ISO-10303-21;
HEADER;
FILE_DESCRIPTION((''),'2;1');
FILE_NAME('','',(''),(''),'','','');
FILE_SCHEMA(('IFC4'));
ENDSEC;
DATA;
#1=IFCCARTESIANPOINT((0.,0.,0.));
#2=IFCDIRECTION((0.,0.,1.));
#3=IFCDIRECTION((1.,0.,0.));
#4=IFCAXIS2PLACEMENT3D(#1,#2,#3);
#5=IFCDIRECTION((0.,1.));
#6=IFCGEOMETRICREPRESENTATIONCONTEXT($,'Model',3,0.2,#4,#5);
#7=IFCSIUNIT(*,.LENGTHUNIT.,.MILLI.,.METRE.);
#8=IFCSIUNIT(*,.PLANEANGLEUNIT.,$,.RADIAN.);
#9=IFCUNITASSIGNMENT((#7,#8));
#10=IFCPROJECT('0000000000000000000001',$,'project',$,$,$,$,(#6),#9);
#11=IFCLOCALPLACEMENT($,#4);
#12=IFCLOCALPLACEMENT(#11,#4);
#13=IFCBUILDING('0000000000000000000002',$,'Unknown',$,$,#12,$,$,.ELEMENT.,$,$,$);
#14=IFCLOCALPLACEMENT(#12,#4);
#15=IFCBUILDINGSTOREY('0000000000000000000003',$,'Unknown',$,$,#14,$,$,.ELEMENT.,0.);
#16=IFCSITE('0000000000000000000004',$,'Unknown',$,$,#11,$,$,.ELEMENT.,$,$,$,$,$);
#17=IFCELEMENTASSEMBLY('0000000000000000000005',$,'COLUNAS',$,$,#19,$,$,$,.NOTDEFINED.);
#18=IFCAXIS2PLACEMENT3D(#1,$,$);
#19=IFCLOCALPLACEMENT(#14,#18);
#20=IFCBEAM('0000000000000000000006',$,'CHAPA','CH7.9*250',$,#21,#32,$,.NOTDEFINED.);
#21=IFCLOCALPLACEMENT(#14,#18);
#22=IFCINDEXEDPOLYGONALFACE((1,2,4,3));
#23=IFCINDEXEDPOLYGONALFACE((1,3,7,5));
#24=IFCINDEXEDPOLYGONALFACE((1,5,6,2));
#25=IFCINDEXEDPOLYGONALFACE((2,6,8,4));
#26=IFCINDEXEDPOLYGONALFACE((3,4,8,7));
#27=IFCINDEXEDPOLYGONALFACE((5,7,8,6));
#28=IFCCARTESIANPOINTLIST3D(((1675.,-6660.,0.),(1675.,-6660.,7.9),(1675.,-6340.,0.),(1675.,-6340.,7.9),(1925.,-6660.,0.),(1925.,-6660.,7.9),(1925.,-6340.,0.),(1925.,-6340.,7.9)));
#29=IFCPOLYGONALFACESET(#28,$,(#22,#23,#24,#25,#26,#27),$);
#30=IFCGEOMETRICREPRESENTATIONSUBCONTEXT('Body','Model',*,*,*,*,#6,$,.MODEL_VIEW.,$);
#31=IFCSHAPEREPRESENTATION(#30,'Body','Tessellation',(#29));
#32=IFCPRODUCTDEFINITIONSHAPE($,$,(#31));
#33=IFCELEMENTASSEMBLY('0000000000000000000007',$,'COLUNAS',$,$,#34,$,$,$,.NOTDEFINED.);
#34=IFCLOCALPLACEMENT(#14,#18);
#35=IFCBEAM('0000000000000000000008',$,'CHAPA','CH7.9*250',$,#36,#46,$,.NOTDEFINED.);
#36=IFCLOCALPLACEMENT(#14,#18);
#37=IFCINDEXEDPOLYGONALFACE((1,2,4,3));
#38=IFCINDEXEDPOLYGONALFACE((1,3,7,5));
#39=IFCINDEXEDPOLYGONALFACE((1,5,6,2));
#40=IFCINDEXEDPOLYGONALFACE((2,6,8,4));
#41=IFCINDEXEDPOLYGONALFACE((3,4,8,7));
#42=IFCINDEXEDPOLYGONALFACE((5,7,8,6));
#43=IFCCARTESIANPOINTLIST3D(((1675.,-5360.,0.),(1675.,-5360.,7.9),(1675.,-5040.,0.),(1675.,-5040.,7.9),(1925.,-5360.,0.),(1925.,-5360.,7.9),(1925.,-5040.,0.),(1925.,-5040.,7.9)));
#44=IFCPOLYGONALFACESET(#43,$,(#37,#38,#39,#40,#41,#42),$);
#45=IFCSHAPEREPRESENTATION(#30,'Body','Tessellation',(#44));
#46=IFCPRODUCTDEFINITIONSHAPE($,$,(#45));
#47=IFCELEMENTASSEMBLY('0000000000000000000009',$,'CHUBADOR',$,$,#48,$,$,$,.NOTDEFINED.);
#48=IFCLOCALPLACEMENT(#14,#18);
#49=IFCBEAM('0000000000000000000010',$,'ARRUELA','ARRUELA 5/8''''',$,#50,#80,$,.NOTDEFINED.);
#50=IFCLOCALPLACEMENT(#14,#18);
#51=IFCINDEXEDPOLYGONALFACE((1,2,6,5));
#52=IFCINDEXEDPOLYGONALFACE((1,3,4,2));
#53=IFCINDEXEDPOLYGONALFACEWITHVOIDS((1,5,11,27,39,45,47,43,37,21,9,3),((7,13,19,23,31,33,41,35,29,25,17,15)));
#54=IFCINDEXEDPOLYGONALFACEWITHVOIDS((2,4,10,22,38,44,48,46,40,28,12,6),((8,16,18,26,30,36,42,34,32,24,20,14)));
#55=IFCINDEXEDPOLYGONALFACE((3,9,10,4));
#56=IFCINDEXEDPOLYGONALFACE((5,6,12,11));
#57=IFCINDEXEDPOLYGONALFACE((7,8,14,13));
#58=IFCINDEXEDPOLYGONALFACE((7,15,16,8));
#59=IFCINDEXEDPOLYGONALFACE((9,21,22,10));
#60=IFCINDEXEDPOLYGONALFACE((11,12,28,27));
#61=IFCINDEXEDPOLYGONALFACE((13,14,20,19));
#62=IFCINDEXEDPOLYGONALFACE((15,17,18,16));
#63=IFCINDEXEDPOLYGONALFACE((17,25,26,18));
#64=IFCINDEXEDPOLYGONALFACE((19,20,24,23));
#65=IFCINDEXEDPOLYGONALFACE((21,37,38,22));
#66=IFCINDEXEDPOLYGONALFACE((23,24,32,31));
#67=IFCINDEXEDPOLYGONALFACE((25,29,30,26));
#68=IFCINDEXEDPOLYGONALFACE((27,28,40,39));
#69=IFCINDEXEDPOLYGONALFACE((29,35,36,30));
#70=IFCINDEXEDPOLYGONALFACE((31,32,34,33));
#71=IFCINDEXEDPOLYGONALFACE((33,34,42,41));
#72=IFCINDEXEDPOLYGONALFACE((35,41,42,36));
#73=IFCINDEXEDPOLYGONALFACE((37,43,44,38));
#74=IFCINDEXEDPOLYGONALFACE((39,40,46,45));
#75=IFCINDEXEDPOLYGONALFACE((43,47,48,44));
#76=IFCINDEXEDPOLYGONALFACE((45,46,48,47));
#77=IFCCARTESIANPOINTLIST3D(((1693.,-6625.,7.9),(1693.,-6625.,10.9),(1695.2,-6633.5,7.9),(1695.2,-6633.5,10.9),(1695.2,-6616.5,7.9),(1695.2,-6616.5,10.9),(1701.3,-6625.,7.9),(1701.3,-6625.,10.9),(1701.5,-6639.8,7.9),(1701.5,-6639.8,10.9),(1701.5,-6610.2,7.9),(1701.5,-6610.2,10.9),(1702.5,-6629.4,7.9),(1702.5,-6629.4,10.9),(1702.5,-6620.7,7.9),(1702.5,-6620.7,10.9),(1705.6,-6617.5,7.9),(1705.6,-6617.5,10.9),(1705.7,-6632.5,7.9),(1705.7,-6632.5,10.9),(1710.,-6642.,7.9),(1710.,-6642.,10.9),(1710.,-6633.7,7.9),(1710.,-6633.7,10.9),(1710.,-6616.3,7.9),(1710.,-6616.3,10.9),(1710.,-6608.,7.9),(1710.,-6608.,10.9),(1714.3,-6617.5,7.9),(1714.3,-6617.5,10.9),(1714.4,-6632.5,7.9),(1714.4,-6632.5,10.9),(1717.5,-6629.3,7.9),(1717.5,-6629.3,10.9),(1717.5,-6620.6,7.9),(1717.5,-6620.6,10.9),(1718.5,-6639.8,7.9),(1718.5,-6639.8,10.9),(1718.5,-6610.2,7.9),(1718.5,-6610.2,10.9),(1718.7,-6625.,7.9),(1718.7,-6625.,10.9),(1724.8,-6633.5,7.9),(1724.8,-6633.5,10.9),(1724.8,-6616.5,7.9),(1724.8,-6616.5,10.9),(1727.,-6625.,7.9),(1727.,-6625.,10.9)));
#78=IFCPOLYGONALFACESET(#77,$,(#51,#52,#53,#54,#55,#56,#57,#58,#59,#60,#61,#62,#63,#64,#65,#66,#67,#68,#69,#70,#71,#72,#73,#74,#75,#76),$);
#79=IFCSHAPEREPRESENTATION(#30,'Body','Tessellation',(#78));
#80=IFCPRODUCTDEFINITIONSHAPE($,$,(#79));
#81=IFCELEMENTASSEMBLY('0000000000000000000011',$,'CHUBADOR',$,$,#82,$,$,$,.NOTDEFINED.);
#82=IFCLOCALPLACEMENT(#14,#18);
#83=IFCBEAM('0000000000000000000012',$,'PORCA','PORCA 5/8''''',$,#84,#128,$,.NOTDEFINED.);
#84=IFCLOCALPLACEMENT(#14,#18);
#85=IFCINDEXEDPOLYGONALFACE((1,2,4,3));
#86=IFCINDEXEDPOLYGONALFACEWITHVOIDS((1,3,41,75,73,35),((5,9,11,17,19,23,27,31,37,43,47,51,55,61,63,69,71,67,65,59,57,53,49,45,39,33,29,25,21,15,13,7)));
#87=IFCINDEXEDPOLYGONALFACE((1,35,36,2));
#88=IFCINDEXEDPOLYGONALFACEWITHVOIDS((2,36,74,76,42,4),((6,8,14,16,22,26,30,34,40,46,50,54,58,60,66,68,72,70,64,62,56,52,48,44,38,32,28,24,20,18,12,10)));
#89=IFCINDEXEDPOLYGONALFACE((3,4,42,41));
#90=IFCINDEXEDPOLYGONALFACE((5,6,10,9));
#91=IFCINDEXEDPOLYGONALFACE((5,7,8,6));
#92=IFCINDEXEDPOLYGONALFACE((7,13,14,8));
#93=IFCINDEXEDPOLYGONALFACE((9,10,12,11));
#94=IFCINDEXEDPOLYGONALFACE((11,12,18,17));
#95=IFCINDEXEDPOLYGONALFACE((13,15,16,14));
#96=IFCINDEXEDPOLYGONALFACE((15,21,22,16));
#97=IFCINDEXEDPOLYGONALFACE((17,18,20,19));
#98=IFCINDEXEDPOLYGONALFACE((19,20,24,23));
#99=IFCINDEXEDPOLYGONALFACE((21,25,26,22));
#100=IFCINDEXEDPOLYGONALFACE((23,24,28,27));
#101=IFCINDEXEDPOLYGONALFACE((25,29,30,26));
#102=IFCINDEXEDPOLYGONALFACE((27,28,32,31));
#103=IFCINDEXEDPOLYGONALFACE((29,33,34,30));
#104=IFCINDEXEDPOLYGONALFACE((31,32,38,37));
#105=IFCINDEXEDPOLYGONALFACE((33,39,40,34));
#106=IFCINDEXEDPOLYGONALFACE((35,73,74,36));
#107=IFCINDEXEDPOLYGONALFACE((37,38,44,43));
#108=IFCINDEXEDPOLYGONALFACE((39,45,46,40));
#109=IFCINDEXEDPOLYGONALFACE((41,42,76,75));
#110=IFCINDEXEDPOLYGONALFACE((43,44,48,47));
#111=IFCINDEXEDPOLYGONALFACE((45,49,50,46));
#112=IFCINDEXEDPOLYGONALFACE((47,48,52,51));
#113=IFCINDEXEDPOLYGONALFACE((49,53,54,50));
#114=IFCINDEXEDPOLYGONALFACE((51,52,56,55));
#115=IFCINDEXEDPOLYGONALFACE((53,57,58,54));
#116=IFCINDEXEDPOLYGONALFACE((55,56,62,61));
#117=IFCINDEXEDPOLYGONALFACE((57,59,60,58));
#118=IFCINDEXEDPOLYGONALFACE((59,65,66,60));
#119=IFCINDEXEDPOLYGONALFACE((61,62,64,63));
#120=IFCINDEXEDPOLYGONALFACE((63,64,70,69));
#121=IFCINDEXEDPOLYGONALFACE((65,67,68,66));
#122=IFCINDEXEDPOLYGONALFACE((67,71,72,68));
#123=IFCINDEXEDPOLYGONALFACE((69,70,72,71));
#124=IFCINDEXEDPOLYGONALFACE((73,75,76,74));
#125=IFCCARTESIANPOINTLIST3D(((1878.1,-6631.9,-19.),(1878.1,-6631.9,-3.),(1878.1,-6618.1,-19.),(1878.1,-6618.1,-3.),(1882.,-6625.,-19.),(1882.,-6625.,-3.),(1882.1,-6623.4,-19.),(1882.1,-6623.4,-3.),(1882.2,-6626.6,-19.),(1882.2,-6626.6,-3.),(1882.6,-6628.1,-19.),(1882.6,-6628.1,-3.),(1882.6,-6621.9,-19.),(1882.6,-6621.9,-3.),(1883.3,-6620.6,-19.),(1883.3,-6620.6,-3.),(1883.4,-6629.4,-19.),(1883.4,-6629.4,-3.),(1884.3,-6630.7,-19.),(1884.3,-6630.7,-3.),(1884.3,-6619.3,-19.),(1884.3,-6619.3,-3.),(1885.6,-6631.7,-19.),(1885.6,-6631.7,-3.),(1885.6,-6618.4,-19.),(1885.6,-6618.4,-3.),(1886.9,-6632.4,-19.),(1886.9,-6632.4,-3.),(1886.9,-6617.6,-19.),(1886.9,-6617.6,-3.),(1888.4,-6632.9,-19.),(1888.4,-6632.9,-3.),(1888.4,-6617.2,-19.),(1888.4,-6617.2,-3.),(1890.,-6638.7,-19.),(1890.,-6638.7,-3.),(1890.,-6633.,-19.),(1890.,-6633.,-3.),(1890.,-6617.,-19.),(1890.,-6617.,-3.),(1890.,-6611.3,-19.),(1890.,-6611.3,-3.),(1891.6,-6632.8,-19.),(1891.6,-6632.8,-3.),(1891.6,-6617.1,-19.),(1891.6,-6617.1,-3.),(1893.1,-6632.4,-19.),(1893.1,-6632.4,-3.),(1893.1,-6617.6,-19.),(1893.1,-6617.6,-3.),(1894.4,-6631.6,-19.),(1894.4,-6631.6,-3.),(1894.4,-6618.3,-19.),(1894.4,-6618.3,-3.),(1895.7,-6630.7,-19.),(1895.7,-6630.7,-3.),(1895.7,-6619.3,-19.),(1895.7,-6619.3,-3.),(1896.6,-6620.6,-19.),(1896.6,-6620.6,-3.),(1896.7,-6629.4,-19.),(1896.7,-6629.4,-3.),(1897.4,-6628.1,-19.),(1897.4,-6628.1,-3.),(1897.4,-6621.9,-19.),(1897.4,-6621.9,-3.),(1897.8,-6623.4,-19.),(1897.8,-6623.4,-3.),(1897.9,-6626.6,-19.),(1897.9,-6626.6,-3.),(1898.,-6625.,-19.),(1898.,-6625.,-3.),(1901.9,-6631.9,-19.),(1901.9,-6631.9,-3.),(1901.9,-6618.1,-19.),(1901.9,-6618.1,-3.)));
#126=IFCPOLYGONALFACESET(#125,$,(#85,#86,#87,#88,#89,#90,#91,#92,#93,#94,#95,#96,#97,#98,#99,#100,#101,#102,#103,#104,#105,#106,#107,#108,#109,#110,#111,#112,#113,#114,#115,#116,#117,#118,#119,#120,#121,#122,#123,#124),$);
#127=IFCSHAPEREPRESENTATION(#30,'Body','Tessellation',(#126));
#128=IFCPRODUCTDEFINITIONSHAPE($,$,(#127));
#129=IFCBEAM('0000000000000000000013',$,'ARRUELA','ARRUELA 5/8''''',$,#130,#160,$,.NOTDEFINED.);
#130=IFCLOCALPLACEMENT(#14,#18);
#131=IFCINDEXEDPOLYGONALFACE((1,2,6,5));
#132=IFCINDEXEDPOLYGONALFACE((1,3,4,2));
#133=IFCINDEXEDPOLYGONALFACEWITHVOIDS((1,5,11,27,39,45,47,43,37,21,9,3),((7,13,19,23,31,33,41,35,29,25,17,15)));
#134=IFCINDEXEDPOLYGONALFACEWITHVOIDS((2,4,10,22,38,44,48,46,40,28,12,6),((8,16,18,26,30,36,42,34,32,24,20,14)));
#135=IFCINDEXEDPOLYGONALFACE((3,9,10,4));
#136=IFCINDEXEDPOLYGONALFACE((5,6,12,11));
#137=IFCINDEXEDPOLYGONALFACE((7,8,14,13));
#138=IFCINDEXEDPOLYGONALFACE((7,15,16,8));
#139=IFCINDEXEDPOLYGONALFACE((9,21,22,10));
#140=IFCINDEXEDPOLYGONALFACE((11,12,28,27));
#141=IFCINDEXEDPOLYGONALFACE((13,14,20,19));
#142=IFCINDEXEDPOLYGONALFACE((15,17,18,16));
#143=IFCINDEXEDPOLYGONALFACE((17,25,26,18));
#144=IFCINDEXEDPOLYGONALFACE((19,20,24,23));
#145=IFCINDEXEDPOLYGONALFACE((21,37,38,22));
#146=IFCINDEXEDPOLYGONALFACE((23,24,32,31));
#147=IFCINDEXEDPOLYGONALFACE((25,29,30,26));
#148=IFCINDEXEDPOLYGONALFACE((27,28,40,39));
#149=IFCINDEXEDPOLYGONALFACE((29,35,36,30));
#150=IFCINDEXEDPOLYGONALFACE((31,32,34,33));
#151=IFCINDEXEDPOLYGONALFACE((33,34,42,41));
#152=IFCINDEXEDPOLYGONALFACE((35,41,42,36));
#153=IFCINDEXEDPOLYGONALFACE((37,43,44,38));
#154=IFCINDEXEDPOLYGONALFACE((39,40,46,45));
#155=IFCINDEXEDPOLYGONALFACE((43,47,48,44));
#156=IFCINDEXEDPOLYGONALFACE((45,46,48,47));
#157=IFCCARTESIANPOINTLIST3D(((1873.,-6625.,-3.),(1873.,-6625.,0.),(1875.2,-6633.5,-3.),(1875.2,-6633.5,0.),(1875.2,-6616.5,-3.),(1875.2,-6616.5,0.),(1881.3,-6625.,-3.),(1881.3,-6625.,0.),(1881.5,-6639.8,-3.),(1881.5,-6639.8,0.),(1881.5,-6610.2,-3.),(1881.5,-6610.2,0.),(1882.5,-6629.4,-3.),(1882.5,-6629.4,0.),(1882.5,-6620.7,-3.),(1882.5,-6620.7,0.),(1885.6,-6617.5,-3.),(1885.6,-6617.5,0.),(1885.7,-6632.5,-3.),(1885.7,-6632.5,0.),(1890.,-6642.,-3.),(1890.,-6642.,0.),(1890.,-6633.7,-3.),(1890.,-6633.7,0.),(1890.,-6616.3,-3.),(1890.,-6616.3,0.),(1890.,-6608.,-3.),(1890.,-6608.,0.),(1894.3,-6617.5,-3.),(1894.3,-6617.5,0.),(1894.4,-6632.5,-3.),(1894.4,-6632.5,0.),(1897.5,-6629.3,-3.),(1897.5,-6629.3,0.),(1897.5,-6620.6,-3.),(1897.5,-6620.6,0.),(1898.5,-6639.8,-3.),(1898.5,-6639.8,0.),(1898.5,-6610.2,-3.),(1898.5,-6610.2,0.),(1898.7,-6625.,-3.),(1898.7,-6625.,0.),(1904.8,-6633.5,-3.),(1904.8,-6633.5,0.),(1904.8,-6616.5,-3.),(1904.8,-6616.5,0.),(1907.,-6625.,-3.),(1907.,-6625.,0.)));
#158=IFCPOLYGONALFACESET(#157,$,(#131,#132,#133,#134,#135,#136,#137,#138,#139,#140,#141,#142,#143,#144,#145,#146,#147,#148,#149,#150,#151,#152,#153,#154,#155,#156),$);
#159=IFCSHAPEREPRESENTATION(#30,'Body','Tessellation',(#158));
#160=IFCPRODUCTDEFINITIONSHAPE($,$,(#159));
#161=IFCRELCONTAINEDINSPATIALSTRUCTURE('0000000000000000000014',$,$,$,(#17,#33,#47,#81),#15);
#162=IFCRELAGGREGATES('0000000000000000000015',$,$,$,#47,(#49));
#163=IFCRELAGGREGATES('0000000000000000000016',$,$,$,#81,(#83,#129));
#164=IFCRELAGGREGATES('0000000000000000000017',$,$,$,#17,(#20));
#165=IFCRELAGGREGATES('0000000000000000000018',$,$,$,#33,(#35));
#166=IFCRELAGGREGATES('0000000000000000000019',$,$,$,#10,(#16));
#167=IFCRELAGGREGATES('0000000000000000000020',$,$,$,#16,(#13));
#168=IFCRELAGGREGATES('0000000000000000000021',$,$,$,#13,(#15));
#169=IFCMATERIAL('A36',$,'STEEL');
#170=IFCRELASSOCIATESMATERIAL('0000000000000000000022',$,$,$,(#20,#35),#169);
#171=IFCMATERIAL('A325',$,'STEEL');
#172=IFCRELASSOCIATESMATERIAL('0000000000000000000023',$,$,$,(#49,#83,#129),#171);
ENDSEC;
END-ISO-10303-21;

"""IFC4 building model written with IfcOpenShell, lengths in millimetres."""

from ifc_helpers import new_model, si_unit, direction, frame, origin_with_axes, place, context, subcontext, project, spatial, line, indexed_curve, outline, extrude, material, element, aggregate, save


model = new_model("IFC4")

# Units and contexts
model_context = context("Model", 3, precision=0.2, world=origin_with_axes(), true_north=direction((0.0, 1.0)))
body_context = subcontext(model_context, "Body", "Model", "MODEL_VIEW")
ifc_project = project(units=[si_unit("LENGTHUNIT", "METRE", prefix="MILLI"), si_unit("PLANEANGLEUNIT", "RADIAN")], contexts=[model_context])

# Site, building, storey
site_placement = place(None, origin_with_axes())
site = spatial("IfcSite", under=ifc_project, at=site_placement, Name="Unknown", CompositionType="ELEMENT")
building_placement = place(site_placement, origin_with_axes())
building = spatial("IfcBuilding", under=site, at=building_placement, Name="Unknown", CompositionType="ELEMENT")
storey_placement = place(building_placement, origin_with_axes())
storey = spatial("IfcBuildingStorey", under=building, at=storey_placement, Name="Unknown", CompositionType="ELEMENT", Elevation=0.0)

# Element assemblies, beams
assembly_1_placement = place(storey_placement, frame((1800.0, -6500.0, 3557.7), z_axis=(-1.0, 0.0, 0.0), x_axis=(0.0, 0.0, -1.0)))
assembly_1 = element("IfcElementAssembly", 1, at=assembly_1_placement, inside=storey, Name="COLUNAS", PredefinedType="NOTDEFINED")
ifc_material_1 = material(Name="A36", Category="STEEL")
beam_1_placement = place(assembly_1_placement, frame((3553.7, -160.0, 0.0), z_axis=(-1.0, 0.0, 0.0), x_axis=(0.0, 1.0, 0.0)))
beam_1 = element("IfcBeam", 2, at=beam_1_placement, material=ifc_material_1, Name="CHAPA", Description="CH7.9*250", PredefinedType="NOTDEFINED", context=body_context, shape_type="SolidModel", body=[
    extrude(outline(indexed_curve([(-4.0, -125.0), (4.0, -125.0), (4.0, 125.0), (-4.0, 125.0)], segments=[line(1, 2, 3, 4, 1)])), frame((0.0, 0.0, 0.0), z_axis=(-1.0, 0.0, 0.0), x_axis=(0.0, 0.0, 1.0)), (0.0, 0.0, -1.0), 320.0),
])
assembly_2_placement = place(storey_placement, frame((1800.0, -5200.0, 3197.6), z_axis=(-1.0, 0.0, 0.0), x_axis=(0.0, 0.0, -1.0)))
assembly_2 = element("IfcElementAssembly", 3, at=assembly_2_placement, inside=storey, Name="COLUNAS", PredefinedType="NOTDEFINED")
beam_2_placement = place(assembly_2_placement, frame((3193.6, -160.0, 0.0), z_axis=(-1.0, 0.0, 0.0), x_axis=(0.0, 1.0, 0.0)))
beam_2 = element("IfcBeam", 4, at=beam_2_placement, material=ifc_material_1, Name="CHAPA", Description="CH7.9*250", PredefinedType="NOTDEFINED", context=body_context, shape_type="SolidModel", body=[
    extrude(outline(indexed_curve([(-4.0, -125.0), (4.0, -125.0), (4.0, 125.0), (-4.0, 125.0)], segments=[line(1, 2, 3, 4, 1)])), frame((0.0, 0.0, 0.0), z_axis=(-1.0, 0.0, 0.0), x_axis=(0.0, 0.0, 1.0)), (0.0, 0.0, -1.0), 320.0),
])
assembly_3_placement = place(storey_placement, frame((1710.0, -6625.0, -52.1), z_axis=(-1.0, 0.0, 0.0), x_axis=(0.0, 0.0, -1.0)))
assembly_3 = element("IfcElementAssembly", 5, at=assembly_3_placement, inside=storey, Name="CHUBADOR", PredefinedType="NOTDEFINED")
ifc_material_2 = material(Name="A325", Category="STEEL")
beam_3_placement = place(assembly_3_placement, frame((-63.0, 0.0, 0.0), z_axis=(0.0, 0.0, 1.0), x_axis=(1.0, 0.0, 0.0)))
beam_3 = element("IfcBeam", 6, at=beam_3_placement, material=ifc_material_2, Name="ARRUELA", Description="ARRUELA 5/8''", PredefinedType="NOTDEFINED", context=body_context, shape_type="SolidModel", body=[
    extrude(outline(indexed_curve([(17.0, 0.0), (14.8, 8.5), (8.5, 14.8), (0.0, 17.0), (-8.5, 14.8), (-14.8, 8.5), (-17.0, 0.0), (-14.8, -8.5), (-8.5, -14.8), (0.0, -17.0), (8.5, -14.8), (14.8, -8.5)], segments=[line(1, 2, 3, 4, 5, 6, 7, 8, 9, 10, 11, 12, 1)]), holes=[indexed_curve([(8.7, 0.0), (7.5, -4.3), (4.3, -7.5), (0.0, -8.7), (-4.3, -7.5), (-7.5, -4.3), (-8.7, 0.0), (-7.5, 4.3), (-4.3, 7.5), (0.0, 8.7), (4.3, 7.5), (7.5, 4.3)], segments=[line(1, 2, 3, 4, 5, 6, 7, 8, 9, 10, 11, 12, 1)])]), frame((0.0, 0.0, 0.0), z_axis=(-1.0, 0.0, 0.0), x_axis=(0.0, 0.0, 1.0)), (0.0, 0.0, -1.0), 3.0),
])
aggregate(assembly_3, [beam_3])

# Element assembly, beams
assembly_4_placement = place(storey_placement, frame((1890.0, -6625.0, -52.1), z_axis=(1.0, 0.0, 0.0), x_axis=(0.0, 0.0, -1.0)))
assembly_4 = element("IfcElementAssembly", 7, at=assembly_4_placement, inside=storey, Name="CHUBADOR", PredefinedType="NOTDEFINED")
beam_4_placement = place(assembly_4_placement, frame((-49.1, 0.0, 0.0), z_axis=(0.0, 0.0, 1.0), x_axis=(1.0, 0.0, 0.0)))
beam_4 = element("IfcBeam", 8, at=beam_4_placement, material=ifc_material_2, Name="PORCA", Description="PORCA 5/8''", PredefinedType="NOTDEFINED", context=body_context, shape_type="SolidModel", body=[
    extrude(outline(indexed_curve([(0.0, 13.8), (-11.9, 6.9), (-11.9, -6.9), (0.0, -13.8), (11.9, -6.9), (11.9, 6.9)], segments=[line(1, 2, 3, 4, 5, 6, 1)]), holes=[indexed_curve([(7.8, 1.6), (8.0, 0.0), (7.8, -1.6), (7.4, -3.1), (6.7, -4.4), (5.7, -5.7), (4.4, -6.7), (3.1, -7.4), (1.6, -7.8), (0.0, -8.0), (-1.6, -7.8), (-3.1, -7.4), (-4.4, -6.7), (-5.7, -5.7), (-6.7, -4.4), (-7.4, -3.1), (-7.8, -1.6), (-8.0, 0.0), (-7.8, 1.6), (-7.4, 3.1), (-6.7, 4.4), (-5.7, 5.7), (-4.4, 6.7), (-3.1, 7.4), (-1.6, 7.8), (0.0, 8.0), (1.6, 7.8), (3.1, 7.4), (4.4, 6.7), (5.7, 5.7), (6.7, 4.4), (7.4, 3.1)], segments=[line(1, 2, 3, 4, 5, 6, 7, 8, 9, 10, 11, 12, 13, 14, 15, 16, 17, 18, 19, 20, 21, 22, 23, 24, 25, 26, 27, 28, 29, 30, 31, 32, 1)])]), frame((0.0, 0.0, 0.0), z_axis=(-1.0, 0.0, 0.0), x_axis=(0.0, 0.0, 1.0)), (0.0, 0.0, -1.0), 16.0),
])
beam_5_placement = place(assembly_4_placement, frame((-52.1, 0.0, 0.0), z_axis=(0.0, 0.0, 1.0), x_axis=(1.0, 0.0, 0.0)))
beam_5 = element("IfcBeam", 9, at=beam_5_placement, material=ifc_material_2, Name="ARRUELA", Description="ARRUELA 5/8''", PredefinedType="NOTDEFINED", context=body_context, shape_type="SolidModel", body=[
    extrude(outline(indexed_curve([(17.0, 0.0), (14.8, 8.5), (8.5, 14.8), (0.0, 17.0), (-8.5, 14.8), (-14.8, 8.5), (-17.0, 0.0), (-14.8, -8.5), (-8.5, -14.8), (0.0, -17.0), (8.5, -14.8), (14.8, -8.5)], segments=[line(1, 2, 3, 4, 5, 6, 7, 8, 9, 10, 11, 12, 1)]), holes=[indexed_curve([(8.7, 0.0), (7.5, -4.3), (4.3, -7.5), (0.0, -8.7), (-4.3, -7.5), (-7.5, -4.3), (-8.7, 0.0), (-7.5, 4.3), (-4.3, 7.5), (0.0, 8.7), (4.3, 7.5), (7.5, 4.3)], segments=[line(1, 2, 3, 4, 5, 6, 7, 8, 9, 10, 11, 12, 1)])]), frame((0.0, 0.0, 0.0), z_axis=(-1.0, 0.0, 0.0), x_axis=(0.0, 0.0, 1.0)), (0.0, 0.0, -1.0), 3.0),
])
aggregate(assembly_4, [beam_4, beam_5])

aggregate(assembly_1, [beam_1])
aggregate(assembly_2, [beam_2])

save(model, "model.ifc")
